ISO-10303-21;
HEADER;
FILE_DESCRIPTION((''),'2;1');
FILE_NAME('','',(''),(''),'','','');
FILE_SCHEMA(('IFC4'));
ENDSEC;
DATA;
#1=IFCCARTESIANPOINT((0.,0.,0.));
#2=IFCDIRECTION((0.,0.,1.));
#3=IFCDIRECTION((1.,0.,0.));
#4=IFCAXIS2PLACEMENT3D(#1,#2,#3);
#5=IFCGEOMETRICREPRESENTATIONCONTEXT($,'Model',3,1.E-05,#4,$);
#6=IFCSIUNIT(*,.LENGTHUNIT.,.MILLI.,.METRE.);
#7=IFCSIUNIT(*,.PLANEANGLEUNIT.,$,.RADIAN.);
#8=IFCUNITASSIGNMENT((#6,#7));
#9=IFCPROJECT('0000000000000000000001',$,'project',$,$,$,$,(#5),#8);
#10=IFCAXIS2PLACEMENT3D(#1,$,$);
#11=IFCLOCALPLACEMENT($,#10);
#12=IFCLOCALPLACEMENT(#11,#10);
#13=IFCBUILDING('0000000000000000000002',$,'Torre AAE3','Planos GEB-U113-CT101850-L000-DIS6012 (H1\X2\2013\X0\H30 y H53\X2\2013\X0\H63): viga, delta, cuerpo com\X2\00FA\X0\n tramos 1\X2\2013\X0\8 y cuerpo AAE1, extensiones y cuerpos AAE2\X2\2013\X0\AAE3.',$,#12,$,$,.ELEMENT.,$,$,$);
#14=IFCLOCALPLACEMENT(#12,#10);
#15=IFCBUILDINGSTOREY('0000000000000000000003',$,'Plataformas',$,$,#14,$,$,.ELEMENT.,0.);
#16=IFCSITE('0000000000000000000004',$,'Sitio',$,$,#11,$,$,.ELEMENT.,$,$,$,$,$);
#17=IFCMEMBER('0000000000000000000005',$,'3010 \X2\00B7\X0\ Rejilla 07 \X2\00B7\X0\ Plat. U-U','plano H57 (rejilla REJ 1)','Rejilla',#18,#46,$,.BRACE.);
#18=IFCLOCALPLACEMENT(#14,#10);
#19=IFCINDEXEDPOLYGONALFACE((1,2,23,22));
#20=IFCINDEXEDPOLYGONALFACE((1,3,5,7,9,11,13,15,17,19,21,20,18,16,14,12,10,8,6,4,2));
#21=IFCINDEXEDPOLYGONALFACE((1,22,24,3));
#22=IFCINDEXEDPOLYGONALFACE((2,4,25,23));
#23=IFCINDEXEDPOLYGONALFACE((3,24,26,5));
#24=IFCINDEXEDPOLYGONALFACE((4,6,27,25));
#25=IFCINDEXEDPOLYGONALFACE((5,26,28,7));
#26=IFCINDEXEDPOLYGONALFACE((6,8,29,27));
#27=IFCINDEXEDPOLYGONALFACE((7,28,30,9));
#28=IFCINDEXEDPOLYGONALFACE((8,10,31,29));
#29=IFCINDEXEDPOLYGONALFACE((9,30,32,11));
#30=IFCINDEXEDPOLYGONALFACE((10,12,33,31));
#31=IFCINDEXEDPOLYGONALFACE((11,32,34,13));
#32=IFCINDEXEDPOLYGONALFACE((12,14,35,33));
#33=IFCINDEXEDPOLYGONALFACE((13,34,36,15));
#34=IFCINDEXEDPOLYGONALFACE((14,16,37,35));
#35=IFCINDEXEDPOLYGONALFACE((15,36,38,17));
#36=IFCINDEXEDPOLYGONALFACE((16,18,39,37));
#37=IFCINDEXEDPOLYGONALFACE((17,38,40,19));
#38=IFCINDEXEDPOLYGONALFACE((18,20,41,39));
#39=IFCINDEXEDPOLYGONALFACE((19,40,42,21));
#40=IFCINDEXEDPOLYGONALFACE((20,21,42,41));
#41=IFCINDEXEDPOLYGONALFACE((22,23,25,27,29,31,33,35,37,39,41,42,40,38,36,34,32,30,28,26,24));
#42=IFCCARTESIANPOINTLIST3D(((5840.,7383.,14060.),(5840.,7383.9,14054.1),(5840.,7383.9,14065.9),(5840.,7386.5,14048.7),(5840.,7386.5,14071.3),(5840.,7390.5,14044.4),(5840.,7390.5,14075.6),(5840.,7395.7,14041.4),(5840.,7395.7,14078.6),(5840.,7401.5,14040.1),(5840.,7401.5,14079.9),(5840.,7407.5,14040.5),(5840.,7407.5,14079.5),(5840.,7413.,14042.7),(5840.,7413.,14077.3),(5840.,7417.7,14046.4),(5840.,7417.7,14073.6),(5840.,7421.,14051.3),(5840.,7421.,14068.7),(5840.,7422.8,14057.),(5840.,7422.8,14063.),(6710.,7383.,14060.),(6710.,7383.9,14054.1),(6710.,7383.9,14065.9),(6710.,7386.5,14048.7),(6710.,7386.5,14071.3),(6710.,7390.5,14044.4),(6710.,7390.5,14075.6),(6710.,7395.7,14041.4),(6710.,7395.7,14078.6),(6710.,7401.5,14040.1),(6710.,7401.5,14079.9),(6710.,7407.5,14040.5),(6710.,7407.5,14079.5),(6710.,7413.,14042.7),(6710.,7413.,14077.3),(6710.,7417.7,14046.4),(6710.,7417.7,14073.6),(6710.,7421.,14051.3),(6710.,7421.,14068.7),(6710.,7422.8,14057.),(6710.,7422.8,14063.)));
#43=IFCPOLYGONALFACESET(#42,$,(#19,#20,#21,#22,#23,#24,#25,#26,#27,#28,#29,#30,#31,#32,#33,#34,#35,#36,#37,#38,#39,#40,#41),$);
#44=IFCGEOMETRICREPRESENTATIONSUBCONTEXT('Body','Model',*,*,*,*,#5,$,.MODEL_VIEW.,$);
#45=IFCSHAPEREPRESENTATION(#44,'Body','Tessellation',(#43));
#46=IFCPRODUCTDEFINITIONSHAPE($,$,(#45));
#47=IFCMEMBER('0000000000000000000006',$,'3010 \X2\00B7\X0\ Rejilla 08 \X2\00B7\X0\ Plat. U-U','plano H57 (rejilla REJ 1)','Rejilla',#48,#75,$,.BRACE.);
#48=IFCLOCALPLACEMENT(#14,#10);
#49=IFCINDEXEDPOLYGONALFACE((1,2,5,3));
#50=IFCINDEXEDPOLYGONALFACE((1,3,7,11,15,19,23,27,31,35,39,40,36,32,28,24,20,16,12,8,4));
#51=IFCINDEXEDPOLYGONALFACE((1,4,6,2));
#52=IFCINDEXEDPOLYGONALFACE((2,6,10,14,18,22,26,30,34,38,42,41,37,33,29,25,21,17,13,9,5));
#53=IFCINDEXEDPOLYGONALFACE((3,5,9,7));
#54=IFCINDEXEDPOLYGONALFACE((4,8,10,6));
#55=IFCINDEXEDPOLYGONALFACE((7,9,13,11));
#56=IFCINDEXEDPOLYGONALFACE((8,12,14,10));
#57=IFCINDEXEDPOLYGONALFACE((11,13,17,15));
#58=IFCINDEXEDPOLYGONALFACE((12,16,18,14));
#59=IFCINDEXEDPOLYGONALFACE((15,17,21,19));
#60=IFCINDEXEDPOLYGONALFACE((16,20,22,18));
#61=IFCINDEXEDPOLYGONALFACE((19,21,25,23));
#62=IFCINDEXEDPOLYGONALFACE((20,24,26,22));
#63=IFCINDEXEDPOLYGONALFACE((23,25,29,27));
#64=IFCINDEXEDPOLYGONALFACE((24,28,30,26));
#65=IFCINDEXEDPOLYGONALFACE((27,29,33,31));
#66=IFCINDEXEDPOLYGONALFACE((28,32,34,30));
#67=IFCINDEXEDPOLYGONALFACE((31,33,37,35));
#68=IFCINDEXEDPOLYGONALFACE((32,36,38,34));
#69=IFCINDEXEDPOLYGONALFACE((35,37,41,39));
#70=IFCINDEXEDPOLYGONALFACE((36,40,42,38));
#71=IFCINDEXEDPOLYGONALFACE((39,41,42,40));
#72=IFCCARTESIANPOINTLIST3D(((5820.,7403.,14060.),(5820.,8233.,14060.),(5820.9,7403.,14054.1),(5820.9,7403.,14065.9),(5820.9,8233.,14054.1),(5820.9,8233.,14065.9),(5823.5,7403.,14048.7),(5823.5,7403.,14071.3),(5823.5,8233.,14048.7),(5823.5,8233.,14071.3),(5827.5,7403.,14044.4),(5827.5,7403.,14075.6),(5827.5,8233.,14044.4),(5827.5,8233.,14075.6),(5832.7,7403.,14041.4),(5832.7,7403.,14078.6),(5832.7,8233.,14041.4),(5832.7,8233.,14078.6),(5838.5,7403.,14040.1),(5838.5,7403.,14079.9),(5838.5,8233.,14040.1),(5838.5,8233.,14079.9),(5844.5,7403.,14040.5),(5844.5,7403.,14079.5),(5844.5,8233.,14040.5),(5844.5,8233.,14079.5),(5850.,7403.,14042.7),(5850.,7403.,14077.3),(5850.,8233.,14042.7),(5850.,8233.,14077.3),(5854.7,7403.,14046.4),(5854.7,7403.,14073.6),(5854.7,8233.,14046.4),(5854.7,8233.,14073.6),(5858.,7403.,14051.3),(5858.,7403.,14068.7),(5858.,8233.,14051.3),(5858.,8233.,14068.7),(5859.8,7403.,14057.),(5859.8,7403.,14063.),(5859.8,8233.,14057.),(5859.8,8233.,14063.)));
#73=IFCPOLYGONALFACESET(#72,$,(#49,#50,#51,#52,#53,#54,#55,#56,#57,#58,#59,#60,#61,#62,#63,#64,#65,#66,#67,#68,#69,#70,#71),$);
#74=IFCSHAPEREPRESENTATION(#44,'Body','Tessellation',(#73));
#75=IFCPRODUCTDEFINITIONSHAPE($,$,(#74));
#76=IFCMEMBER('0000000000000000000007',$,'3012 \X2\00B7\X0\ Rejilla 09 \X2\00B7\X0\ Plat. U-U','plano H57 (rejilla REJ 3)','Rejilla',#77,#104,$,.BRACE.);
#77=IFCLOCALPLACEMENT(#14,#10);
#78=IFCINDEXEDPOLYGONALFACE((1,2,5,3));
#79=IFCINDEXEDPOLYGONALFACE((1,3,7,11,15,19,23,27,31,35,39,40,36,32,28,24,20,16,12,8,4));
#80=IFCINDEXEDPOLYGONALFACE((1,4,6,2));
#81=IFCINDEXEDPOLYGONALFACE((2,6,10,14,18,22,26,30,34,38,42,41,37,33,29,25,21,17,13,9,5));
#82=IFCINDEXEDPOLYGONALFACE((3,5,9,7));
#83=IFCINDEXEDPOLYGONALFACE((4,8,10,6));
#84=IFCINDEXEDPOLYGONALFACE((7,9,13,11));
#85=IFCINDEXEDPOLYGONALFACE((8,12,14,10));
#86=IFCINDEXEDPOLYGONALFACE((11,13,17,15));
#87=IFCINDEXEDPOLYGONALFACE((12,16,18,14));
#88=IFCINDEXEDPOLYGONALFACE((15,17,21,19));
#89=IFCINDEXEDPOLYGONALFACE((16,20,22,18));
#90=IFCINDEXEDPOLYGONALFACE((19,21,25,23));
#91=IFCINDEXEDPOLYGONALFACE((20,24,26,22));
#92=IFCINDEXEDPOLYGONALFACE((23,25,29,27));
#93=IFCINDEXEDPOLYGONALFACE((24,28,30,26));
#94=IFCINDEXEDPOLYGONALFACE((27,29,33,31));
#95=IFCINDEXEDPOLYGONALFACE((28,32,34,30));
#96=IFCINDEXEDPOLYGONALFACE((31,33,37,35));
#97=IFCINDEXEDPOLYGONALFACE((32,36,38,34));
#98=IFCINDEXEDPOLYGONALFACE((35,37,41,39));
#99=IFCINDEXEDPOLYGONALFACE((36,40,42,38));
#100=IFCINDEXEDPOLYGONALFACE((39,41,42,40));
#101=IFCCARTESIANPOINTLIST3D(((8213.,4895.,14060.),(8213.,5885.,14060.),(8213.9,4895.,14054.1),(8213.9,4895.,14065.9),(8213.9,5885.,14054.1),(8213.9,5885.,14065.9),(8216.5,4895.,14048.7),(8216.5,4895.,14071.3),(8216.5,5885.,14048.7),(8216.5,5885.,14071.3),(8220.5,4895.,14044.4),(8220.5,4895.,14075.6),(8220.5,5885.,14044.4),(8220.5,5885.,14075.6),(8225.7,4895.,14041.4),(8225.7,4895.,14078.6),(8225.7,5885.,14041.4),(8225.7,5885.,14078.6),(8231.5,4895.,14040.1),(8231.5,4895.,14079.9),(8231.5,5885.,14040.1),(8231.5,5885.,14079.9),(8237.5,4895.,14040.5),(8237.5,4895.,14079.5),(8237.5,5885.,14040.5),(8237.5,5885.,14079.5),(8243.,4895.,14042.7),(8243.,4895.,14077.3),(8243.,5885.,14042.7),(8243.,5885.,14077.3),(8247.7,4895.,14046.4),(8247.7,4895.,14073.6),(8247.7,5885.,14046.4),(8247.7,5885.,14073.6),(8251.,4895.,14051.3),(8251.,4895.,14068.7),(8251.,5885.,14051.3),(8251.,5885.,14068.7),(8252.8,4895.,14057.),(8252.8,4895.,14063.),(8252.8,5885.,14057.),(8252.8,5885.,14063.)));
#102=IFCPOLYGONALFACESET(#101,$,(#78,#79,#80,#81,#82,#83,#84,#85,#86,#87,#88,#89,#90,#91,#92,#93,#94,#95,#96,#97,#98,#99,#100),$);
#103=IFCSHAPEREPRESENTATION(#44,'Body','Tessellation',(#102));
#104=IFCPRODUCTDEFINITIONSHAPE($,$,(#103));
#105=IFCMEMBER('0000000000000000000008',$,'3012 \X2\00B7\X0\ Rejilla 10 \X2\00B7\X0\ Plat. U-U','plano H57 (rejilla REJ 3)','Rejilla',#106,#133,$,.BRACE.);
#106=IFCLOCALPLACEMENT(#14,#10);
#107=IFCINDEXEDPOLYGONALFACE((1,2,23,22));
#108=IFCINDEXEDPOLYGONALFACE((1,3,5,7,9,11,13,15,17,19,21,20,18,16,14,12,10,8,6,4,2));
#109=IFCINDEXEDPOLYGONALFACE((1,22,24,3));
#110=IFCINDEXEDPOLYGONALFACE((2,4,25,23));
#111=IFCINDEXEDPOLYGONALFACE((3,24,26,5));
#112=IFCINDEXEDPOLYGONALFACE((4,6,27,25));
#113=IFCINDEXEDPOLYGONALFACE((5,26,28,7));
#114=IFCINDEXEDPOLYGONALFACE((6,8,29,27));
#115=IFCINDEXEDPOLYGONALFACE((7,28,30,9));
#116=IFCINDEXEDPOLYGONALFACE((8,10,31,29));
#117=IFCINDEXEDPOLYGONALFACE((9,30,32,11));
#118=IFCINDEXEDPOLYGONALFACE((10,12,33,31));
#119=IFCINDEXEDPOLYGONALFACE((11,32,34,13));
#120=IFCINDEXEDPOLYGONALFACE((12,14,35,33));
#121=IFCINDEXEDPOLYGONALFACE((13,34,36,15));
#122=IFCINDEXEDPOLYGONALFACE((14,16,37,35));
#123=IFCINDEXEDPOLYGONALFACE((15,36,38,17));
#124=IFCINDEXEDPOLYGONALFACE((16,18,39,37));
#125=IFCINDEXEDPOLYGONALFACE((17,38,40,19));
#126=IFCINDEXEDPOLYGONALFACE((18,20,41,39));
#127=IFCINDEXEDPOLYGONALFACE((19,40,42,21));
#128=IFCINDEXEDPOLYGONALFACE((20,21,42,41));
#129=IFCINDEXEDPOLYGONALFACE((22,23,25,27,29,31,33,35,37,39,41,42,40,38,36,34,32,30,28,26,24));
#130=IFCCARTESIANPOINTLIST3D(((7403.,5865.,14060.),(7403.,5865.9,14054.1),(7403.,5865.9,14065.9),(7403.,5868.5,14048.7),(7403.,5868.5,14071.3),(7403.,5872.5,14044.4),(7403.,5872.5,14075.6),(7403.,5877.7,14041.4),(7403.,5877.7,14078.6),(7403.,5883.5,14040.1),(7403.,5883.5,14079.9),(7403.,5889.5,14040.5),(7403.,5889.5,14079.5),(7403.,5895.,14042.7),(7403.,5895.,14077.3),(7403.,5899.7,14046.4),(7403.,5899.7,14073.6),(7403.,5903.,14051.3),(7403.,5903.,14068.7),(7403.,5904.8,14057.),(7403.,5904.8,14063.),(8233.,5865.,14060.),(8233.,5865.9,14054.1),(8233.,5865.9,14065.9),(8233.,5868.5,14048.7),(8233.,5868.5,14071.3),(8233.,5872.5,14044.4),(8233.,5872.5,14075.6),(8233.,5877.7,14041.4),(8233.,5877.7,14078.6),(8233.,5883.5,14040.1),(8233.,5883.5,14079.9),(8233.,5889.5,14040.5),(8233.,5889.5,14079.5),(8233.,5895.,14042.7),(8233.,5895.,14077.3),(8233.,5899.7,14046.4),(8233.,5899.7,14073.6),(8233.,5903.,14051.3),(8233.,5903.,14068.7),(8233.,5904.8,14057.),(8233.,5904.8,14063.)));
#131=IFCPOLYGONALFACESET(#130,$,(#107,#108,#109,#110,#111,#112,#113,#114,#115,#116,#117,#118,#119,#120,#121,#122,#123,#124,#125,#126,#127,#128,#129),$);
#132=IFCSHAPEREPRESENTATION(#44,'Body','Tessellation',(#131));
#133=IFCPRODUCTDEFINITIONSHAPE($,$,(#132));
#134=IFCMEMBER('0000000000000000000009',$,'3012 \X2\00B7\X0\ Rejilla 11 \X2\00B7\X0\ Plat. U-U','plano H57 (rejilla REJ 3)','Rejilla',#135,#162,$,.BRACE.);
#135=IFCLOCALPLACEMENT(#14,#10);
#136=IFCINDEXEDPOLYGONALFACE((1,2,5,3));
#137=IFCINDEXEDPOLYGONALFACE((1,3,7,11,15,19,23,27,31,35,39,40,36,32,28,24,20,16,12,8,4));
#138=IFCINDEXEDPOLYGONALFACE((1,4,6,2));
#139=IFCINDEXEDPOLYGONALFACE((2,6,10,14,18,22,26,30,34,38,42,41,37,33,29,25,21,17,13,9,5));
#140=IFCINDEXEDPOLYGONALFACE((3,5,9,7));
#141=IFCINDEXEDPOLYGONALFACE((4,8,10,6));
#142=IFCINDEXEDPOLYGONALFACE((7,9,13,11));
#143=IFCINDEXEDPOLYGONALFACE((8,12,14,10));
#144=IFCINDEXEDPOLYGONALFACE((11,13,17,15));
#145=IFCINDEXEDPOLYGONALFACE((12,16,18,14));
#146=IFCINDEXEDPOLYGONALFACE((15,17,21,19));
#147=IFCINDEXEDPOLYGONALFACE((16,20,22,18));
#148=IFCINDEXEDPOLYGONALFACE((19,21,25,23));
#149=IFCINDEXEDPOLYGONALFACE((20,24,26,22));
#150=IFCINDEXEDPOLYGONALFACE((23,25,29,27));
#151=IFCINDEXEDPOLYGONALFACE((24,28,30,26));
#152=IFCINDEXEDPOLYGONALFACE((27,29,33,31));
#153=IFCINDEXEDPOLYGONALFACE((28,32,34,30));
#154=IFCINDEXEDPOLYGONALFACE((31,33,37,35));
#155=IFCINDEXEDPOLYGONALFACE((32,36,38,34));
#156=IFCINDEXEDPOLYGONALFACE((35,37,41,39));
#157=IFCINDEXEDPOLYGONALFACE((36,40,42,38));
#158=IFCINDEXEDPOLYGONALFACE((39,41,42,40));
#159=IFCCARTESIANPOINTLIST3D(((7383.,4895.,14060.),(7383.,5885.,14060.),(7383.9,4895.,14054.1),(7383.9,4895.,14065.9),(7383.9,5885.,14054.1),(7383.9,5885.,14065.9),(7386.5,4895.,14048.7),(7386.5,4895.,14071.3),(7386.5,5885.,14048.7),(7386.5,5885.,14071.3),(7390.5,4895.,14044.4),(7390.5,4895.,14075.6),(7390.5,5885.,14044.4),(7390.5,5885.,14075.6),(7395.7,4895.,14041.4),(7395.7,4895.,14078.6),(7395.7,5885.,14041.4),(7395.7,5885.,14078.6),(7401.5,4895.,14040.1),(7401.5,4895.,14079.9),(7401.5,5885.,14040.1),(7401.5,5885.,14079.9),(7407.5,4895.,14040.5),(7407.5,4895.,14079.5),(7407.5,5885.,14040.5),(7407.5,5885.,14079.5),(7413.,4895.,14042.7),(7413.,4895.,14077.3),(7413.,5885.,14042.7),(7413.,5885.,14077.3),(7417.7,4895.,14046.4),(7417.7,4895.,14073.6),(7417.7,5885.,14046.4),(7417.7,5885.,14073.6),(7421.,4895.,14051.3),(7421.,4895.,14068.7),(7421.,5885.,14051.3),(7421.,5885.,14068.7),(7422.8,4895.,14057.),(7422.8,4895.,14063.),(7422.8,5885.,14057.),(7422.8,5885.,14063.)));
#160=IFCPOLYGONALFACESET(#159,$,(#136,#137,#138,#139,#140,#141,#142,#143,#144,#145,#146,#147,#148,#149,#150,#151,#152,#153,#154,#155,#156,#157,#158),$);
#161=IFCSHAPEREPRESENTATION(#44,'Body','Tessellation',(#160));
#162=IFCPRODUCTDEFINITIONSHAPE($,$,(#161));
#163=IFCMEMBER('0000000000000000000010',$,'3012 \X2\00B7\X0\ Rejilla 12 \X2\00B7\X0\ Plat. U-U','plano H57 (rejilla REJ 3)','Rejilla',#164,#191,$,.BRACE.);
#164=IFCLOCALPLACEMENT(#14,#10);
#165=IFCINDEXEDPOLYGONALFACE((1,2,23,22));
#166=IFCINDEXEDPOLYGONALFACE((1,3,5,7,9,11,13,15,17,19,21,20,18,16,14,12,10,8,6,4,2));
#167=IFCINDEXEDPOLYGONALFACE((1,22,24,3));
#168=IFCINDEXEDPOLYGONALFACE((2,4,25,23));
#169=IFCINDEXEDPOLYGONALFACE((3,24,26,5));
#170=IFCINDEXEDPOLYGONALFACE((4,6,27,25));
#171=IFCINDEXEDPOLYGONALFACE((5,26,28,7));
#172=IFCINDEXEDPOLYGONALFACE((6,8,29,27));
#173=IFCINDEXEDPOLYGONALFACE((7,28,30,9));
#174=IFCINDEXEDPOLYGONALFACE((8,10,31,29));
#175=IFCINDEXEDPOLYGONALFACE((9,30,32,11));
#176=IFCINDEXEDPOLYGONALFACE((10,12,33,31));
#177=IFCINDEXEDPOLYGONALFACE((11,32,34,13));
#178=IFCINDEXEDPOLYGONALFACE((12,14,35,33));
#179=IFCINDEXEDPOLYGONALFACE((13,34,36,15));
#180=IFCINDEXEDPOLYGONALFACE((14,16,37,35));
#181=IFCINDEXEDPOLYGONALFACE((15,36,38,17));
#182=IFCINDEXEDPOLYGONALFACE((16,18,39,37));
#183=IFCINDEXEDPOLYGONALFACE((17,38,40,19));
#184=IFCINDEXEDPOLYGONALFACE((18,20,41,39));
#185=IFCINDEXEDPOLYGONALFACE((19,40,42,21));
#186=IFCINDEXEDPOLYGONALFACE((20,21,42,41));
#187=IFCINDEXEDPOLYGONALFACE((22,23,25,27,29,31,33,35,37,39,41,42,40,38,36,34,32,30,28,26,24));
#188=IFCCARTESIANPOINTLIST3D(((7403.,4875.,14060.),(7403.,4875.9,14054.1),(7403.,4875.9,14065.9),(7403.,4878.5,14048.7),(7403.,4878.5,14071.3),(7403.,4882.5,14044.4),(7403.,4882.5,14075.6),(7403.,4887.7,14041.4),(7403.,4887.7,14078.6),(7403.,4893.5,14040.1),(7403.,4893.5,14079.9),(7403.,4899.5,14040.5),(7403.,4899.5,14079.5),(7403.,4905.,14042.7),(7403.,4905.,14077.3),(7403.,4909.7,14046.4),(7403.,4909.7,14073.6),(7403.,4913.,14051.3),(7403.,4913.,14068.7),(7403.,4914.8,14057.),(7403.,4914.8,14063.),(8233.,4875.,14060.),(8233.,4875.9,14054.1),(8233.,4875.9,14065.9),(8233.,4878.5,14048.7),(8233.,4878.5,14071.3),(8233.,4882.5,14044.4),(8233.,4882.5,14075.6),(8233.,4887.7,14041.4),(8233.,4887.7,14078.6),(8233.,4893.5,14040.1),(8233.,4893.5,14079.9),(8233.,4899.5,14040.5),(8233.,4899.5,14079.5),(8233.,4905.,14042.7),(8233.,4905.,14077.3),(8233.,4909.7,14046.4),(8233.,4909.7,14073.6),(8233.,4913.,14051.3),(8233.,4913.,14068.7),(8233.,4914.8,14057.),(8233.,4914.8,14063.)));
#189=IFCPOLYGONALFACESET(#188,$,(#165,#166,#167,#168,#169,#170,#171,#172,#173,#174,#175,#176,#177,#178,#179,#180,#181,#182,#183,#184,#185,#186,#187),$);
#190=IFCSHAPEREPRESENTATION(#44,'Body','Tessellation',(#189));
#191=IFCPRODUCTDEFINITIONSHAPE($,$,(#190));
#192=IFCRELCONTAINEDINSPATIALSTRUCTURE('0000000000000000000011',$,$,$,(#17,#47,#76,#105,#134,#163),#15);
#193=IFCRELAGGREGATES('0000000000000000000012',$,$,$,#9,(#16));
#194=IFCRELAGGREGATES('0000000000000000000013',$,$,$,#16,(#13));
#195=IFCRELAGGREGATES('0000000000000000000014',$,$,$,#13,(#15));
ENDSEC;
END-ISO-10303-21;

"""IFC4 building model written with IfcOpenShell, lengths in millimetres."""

from ifc_helpers import new_model, si_unit, frame, origin, origin_with_axes, place, context, subcontext, project, spatial, circle, extrude, element, save


model = new_model("IFC4")

# Units and contexts
model_context = context("Model", 3, precision=1e-05, world=origin_with_axes())
body_context = subcontext(model_context, "Body", "Model", "MODEL_VIEW")
ifc_project = project(units=[si_unit("LENGTHUNIT", "METRE", prefix="MILLI"), si_unit("PLANEANGLEUNIT", "RADIAN")], contexts=[model_context])

# Site, building, storey
site_placement = place(None, origin())
site = spatial("IfcSite", under=ifc_project, at=site_placement, Name="Sitio", CompositionType="ELEMENT")
building_placement = place(site_placement, origin())
building = spatial("IfcBuilding", under=site, at=building_placement, Name="Torre AAE3", Description="Planos GEB-U113-CT101850-L000-DIS6012 (H1–H30 y H53–H63): viga, delta, cuerpo común tramos 1–8 y cuerpo AAE1, extensiones y cuerpos AAE2–AAE3.", CompositionType="ELEMENT")
storey_placement = place(building_placement, origin())
storey = spatial("IfcBuildingStorey", under=building, at=storey_placement, Name="Plataformas", CompositionType="ELEMENT", Elevation=0.0)

# Members
member_1_placement = place(storey_placement, frame((6710.0, 7403.0, 14060.0), z_axis=(-1.0, 0.0, 0.0), x_axis=(0.0, -1.0, 0.0)))
element("IfcMember", 1, at=member_1_placement, inside=storey, Name="3010 · Rejilla 07 · Plat. U-U", Description="plano H57 (rejilla REJ 1)", ObjectType="Rejilla", PredefinedType="BRACE", context=body_context, shape_type="SweptSolid", body=[
    extrude(circle(Radius=20.0), None, (0.0, 0.0, 1.0), 870.0),
])
member_2_placement = place(storey_placement, frame((5840.0, 7403.0, 14060.0), z_axis=(0.0, 1.0, 0.0), x_axis=(-1.0, 0.0, 0.0)))
element("IfcMember", 2, at=member_2_placement, inside=storey, Name="3010 · Rejilla 08 · Plat. U-U", Description="plano H57 (rejilla REJ 1)", ObjectType="Rejilla", PredefinedType="BRACE", context=body_context, shape_type="SweptSolid", body=[
    extrude(circle(Radius=20.0), None, (0.0, 0.0, 1.0), 830.0),
])
member_3_placement = place(storey_placement, frame((8233.0, 4895.0, 14060.0), z_axis=(0.0, 1.0, 0.0), x_axis=(-1.0, 0.0, 0.0)))
element("IfcMember", 3, at=member_3_placement, inside=storey, Name="3012 · Rejilla 09 · Plat. U-U", Description="plano H57 (rejilla REJ 3)", ObjectType="Rejilla", PredefinedType="BRACE", context=body_context, shape_type="SweptSolid", body=[
    extrude(circle(Radius=20.0), None, (0.0, 0.0, 1.0), 990.0),
])
member_4_placement = place(storey_placement, frame((8233.0, 5885.0, 14060.0), z_axis=(-1.0, 0.0, 0.0), x_axis=(0.0, -1.0, 0.0)))
element("IfcMember", 4, at=member_4_placement, inside=storey, Name="3012 · Rejilla 10 · Plat. U-U", Description="plano H57 (rejilla REJ 3)", ObjectType="Rejilla", PredefinedType="BRACE", context=body_context, shape_type="SweptSolid", body=[
    extrude(circle(Radius=20.0), None, (0.0, 0.0, 1.0), 830.0),
])
member_5_placement = place(storey_placement, frame((7403.0, 5885.0, 14060.0), z_axis=(0.0, -1.0, 0.0), x_axis=(-1.0, 0.0, 0.0)))
element("IfcMember", 5, at=member_5_placement, inside=storey, Name="3012 · Rejilla 11 · Plat. U-U", Description="plano H57 (rejilla REJ 3)", ObjectType="Rejilla", PredefinedType="BRACE", context=body_context, shape_type="SweptSolid", body=[
    extrude(circle(Radius=20.0), None, (0.0, 0.0, 1.0), 990.0),
])
member_6_placement = place(storey_placement, frame((7403.0, 4895.0, 14060.0), z_axis=(1.0, 0.0, 0.0), x_axis=(0.0, -1.0, 0.0)))
element("IfcMember", 6, at=member_6_placement, inside=storey, Name="3012 · Rejilla 12 · Plat. U-U", Description="plano H57 (rejilla REJ 3)", ObjectType="Rejilla", PredefinedType="BRACE", context=body_context, shape_type="SweptSolid", body=[
    extrude(circle(Radius=20.0), None, (0.0, 0.0, 1.0), 830.0),
])

save(model, "model.ifc")
